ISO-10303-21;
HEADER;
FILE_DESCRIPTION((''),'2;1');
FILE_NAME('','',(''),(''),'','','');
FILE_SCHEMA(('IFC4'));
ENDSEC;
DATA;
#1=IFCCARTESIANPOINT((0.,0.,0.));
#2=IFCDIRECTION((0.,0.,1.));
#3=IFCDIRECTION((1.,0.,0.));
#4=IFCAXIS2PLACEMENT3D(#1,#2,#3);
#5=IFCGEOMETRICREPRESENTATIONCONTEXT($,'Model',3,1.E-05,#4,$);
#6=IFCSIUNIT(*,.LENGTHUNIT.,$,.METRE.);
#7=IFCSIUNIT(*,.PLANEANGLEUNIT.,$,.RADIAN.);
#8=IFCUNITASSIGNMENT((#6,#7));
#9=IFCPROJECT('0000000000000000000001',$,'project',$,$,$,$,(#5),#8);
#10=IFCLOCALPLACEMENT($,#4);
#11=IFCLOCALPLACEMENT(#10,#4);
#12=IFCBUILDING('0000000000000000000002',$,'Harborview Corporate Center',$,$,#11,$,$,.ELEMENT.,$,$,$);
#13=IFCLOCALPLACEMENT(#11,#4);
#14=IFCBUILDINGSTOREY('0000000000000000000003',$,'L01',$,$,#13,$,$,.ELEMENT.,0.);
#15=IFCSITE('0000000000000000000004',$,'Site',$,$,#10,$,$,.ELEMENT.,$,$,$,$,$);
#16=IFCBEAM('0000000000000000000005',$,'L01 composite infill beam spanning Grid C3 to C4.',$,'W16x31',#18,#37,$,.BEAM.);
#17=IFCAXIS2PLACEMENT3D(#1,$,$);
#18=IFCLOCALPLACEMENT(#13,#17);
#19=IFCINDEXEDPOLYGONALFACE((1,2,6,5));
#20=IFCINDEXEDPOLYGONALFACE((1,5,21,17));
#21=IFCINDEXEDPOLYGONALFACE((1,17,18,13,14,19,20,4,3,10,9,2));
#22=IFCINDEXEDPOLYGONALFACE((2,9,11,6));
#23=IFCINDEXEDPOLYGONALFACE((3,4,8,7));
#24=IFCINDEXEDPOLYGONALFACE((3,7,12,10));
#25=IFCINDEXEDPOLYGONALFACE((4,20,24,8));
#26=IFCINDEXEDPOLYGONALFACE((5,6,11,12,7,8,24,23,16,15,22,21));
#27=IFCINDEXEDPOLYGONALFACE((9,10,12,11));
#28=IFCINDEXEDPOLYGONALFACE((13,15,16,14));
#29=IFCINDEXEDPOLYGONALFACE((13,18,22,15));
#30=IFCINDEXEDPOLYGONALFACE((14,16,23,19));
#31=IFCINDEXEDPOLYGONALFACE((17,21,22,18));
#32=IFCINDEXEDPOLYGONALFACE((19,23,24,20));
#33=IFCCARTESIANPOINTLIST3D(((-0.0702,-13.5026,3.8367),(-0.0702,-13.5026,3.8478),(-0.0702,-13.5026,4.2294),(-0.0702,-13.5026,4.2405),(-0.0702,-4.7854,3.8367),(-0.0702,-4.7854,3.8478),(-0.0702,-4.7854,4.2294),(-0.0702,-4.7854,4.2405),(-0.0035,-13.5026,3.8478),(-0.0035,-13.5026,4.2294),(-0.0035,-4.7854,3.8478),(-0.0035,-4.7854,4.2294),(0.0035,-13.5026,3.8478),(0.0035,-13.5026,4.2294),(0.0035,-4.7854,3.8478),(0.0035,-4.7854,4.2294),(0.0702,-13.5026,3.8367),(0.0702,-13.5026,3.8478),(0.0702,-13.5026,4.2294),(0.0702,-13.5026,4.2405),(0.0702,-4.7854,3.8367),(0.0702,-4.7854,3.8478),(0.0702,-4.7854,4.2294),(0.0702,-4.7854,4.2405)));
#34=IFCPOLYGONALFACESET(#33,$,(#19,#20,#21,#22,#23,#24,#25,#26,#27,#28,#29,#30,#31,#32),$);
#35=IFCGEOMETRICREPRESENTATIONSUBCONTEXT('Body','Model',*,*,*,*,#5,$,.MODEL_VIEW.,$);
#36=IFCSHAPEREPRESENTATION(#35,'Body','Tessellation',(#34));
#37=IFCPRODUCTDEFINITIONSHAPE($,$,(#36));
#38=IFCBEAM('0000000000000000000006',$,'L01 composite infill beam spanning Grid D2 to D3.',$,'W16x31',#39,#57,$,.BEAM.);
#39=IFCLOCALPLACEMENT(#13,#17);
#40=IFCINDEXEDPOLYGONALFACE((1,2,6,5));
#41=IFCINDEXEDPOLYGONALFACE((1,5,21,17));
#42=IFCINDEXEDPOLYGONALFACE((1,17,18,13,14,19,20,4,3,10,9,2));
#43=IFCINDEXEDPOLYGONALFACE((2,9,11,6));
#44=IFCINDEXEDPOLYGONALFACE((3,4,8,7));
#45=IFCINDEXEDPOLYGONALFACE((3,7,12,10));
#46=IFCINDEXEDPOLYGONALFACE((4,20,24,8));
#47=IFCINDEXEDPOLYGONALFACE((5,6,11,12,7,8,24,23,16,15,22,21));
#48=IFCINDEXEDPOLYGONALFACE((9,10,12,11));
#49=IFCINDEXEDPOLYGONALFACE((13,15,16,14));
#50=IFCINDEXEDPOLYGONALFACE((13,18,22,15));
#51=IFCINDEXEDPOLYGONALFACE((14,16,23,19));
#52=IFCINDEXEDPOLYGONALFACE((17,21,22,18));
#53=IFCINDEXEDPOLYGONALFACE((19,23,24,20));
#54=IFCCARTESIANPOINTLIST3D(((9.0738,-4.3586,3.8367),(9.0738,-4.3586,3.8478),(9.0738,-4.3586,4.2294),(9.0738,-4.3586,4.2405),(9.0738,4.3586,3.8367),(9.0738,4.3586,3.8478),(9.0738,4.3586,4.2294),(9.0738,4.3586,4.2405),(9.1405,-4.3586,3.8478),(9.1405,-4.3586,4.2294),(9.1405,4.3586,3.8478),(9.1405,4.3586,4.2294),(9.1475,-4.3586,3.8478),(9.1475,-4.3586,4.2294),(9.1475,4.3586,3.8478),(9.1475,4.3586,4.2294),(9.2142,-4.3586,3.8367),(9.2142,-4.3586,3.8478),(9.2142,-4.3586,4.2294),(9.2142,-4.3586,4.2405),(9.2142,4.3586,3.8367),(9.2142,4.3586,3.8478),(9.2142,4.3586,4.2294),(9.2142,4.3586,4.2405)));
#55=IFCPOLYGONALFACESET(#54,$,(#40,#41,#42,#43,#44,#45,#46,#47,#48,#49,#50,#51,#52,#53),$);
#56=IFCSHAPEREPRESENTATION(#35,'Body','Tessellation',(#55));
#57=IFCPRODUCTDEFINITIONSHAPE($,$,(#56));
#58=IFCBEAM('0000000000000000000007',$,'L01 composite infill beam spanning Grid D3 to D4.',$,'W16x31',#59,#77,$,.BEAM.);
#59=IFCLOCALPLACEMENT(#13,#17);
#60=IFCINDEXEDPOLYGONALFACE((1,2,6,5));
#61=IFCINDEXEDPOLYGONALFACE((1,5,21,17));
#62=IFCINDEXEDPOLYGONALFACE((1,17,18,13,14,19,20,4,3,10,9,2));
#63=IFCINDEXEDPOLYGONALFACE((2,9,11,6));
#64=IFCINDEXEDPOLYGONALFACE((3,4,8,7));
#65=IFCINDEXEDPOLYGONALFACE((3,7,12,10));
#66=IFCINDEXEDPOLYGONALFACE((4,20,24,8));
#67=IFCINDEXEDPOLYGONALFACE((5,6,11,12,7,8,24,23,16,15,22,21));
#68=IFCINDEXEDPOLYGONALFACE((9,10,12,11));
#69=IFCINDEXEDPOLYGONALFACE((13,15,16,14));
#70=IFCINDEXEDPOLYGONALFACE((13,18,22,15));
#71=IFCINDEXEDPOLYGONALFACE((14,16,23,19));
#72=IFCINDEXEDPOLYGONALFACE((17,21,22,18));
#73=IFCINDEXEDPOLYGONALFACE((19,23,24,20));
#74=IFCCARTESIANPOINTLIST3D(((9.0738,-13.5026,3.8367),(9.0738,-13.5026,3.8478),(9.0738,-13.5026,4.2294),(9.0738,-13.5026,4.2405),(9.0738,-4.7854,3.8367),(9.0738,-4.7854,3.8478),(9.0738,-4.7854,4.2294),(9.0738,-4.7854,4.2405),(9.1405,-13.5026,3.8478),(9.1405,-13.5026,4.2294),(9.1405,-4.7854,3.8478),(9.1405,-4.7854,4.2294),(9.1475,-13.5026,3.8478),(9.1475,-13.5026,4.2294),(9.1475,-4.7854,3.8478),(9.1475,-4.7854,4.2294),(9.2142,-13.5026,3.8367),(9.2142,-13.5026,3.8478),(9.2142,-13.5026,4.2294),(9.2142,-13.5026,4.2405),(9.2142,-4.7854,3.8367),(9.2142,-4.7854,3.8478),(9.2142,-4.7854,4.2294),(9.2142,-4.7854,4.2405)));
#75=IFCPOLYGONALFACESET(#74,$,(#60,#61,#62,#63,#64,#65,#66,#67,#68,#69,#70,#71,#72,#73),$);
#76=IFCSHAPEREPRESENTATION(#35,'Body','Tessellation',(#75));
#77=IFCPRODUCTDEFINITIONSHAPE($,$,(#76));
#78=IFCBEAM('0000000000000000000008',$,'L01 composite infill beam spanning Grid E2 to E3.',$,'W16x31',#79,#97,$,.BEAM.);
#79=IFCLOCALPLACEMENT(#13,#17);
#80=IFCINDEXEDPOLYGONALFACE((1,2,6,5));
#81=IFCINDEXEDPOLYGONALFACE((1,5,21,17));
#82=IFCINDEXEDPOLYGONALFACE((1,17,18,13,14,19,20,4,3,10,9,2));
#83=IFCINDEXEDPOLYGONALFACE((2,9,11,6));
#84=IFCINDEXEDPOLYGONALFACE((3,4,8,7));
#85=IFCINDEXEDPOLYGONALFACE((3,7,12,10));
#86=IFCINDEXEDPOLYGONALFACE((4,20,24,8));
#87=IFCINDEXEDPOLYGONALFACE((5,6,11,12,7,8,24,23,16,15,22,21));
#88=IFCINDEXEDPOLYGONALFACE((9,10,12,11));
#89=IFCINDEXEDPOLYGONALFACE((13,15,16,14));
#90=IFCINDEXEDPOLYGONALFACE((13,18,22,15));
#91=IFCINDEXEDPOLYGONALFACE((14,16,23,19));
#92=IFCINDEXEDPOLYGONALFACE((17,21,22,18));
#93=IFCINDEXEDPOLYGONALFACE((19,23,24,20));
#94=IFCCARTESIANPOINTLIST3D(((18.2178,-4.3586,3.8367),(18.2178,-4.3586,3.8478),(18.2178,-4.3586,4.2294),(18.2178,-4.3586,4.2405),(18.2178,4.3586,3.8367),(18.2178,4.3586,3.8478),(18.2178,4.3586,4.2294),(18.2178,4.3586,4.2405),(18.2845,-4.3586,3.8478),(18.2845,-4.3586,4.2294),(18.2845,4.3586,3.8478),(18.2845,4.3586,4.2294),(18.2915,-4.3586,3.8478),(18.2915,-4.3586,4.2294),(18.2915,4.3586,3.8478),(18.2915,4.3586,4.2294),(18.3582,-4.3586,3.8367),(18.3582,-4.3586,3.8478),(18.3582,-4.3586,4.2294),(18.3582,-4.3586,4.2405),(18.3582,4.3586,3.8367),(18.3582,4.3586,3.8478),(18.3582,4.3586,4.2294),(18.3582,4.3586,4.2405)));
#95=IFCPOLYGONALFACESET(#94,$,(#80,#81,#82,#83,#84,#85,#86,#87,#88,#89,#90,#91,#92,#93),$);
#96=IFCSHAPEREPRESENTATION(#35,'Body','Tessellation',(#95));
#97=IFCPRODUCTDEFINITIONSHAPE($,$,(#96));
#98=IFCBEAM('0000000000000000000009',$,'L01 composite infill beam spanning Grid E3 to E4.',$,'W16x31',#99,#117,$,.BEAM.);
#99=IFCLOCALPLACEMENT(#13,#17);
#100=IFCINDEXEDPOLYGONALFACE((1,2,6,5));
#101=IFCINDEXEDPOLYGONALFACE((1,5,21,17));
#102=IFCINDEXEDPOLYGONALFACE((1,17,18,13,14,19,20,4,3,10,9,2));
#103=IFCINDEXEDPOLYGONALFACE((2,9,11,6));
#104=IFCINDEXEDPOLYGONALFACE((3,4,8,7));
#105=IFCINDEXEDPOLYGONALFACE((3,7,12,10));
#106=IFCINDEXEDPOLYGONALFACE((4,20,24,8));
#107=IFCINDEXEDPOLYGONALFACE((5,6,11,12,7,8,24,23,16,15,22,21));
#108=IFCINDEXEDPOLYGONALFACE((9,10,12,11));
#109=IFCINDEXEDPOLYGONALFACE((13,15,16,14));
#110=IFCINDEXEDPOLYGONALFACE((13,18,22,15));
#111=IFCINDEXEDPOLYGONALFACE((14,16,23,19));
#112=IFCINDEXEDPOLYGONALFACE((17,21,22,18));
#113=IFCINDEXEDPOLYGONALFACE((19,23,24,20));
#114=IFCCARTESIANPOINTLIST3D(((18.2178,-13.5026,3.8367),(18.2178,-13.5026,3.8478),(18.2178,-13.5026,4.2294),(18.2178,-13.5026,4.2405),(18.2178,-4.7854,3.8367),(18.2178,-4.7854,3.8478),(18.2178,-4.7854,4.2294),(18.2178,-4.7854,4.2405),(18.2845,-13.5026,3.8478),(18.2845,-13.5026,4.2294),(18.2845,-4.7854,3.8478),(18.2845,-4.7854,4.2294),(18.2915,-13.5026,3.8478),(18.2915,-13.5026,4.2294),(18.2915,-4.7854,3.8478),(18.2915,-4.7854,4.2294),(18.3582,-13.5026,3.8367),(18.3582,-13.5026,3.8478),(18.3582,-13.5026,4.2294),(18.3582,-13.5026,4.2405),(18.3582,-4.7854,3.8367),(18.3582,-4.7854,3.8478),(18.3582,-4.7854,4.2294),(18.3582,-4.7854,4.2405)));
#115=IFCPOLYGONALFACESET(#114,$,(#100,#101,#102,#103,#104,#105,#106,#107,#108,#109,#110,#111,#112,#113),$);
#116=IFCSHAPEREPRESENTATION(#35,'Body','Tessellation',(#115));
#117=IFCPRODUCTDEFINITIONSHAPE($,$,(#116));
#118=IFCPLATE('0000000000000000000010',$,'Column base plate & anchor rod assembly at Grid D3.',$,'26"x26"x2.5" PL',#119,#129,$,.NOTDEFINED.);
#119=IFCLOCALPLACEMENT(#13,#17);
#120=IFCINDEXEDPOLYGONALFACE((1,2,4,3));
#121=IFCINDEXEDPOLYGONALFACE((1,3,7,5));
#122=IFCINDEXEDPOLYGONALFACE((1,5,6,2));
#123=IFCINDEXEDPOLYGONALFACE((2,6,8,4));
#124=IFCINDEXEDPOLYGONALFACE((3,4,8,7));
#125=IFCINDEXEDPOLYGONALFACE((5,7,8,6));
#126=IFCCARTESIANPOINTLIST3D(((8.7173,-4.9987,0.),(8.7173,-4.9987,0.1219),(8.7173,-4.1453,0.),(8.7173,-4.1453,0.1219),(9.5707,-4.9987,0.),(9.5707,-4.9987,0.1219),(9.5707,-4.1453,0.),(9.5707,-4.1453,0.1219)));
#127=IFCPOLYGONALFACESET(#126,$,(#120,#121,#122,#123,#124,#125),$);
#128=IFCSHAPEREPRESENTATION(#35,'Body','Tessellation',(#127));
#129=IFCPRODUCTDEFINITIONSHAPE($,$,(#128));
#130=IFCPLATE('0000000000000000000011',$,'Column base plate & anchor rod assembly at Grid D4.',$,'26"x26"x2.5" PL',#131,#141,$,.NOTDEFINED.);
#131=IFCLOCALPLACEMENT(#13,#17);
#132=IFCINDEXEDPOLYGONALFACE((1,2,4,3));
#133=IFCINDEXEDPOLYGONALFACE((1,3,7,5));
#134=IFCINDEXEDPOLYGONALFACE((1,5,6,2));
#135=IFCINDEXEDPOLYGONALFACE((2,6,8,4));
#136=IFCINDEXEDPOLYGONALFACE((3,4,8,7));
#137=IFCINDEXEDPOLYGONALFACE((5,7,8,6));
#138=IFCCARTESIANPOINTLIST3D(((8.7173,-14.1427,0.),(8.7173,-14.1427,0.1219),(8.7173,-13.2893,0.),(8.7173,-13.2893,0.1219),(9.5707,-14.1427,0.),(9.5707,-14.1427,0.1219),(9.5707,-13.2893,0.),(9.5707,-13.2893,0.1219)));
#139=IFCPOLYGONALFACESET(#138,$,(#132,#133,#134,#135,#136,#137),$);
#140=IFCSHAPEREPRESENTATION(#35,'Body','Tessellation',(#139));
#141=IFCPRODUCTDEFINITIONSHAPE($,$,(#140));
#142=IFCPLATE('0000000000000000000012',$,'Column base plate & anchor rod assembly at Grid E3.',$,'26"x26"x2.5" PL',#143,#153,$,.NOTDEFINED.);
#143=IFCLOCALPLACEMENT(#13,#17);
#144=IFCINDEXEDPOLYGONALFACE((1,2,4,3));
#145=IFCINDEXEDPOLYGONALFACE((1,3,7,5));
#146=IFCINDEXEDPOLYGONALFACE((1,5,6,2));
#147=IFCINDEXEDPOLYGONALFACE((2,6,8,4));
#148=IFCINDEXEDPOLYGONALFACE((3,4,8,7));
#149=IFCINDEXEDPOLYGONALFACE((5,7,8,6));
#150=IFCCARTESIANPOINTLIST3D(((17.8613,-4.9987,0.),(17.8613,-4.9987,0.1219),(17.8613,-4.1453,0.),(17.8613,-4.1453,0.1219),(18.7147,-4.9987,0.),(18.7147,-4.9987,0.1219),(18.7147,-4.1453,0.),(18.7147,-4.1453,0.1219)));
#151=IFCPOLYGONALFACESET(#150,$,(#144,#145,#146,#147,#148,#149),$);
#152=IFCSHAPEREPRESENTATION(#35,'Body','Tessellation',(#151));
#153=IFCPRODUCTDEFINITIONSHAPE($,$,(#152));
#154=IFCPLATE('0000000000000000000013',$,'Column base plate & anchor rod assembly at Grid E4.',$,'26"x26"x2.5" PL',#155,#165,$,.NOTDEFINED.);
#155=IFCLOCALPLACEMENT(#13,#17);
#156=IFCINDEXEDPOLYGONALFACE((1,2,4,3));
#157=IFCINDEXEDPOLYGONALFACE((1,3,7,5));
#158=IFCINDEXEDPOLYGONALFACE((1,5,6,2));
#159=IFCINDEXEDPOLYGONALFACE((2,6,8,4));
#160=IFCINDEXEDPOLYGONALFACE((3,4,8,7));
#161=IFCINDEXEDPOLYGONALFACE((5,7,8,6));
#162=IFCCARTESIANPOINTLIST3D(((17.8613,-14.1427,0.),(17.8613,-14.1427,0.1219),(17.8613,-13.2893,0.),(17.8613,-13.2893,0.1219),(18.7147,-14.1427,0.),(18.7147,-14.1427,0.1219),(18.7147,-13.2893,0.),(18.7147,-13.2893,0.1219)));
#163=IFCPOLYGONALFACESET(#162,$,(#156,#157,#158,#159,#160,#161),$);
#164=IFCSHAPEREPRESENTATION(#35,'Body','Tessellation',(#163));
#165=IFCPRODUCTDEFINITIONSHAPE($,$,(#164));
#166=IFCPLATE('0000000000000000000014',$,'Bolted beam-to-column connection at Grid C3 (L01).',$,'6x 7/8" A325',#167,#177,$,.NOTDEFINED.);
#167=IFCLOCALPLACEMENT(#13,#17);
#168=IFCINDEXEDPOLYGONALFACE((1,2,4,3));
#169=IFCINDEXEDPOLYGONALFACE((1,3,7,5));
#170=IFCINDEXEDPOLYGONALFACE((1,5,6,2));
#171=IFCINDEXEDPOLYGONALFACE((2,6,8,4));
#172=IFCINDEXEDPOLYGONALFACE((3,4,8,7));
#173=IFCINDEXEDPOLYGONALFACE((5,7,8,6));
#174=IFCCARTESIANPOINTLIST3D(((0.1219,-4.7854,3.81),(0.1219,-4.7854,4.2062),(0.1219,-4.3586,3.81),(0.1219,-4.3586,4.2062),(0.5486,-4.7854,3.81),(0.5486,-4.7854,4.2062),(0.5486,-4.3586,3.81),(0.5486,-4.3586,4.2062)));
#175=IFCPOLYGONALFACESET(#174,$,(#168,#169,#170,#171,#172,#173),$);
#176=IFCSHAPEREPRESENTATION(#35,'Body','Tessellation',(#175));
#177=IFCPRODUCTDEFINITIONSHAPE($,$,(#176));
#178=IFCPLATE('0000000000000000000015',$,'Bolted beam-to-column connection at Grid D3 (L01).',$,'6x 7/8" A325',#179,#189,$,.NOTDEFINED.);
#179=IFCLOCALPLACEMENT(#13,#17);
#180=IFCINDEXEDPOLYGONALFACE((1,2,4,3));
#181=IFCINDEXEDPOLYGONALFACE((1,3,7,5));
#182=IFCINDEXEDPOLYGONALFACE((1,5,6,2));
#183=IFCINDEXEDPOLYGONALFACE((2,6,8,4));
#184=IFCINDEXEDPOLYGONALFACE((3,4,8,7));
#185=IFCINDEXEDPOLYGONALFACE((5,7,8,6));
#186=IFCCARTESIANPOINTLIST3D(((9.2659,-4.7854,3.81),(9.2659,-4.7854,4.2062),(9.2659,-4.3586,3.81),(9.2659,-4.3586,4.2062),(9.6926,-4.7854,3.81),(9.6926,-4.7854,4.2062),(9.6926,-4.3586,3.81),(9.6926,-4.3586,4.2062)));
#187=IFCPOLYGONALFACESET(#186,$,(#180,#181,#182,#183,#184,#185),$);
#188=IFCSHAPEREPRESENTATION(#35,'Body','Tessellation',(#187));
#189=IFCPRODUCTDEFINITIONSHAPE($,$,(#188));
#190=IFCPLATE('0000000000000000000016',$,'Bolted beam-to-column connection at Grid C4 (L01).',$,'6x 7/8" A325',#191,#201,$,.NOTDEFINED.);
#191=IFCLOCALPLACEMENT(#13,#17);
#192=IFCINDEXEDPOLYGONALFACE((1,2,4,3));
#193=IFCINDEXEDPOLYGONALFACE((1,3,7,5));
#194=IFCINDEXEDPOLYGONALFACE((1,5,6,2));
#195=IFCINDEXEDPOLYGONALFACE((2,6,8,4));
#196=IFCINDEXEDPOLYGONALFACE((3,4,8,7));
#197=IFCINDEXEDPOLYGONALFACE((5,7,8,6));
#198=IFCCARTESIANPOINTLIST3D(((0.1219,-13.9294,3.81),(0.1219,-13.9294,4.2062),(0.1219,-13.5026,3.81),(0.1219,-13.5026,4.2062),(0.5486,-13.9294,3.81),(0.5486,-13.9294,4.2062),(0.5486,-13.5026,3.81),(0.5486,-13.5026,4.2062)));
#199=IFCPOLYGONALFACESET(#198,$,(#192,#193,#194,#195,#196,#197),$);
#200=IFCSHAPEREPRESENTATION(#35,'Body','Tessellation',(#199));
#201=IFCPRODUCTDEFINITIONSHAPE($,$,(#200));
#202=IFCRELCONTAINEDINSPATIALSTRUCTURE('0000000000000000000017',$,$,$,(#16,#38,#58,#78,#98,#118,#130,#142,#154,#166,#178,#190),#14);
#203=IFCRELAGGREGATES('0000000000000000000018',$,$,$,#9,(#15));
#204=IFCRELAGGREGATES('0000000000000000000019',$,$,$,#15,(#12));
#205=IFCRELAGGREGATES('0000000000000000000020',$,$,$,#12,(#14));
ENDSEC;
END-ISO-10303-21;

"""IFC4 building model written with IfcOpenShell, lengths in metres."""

from ifc_helpers import new_model, si_unit, frame, origin_with_axes, place, context, subcontext, project, spatial, rectangle, i_section, extrude, element, save


model = new_model("IFC4")

# Units and contexts
model_context = context("Model", 3, precision=1e-05, world=origin_with_axes())
body_context = subcontext(model_context, "Body", "Model", "MODEL_VIEW")
ifc_project = project(units=[si_unit("LENGTHUNIT", "METRE"), si_unit("PLANEANGLEUNIT", "RADIAN")], contexts=[model_context])

# Site, building, storey
site_placement = place(None, origin_with_axes())
site = spatial("IfcSite", under=ifc_project, at=site_placement, Name="Site", CompositionType="ELEMENT")
building_placement = place(site_placement, origin_with_axes())
building = spatial("IfcBuilding", under=site, at=building_placement, Name="Harborview Corporate Center", CompositionType="ELEMENT")
storey_placement = place(building_placement, origin_with_axes())
storey = spatial("IfcBuildingStorey", under=building, at=storey_placement, Name="L01", CompositionType="ELEMENT", Elevation=0.0)

# Beams
beam_1_placement = place(storey_placement, frame((0.0, -13.5026, 4.0386), z_axis=(0.0, 1.0, 0.0), x_axis=(-1.0, 0.0, 0.0)))
element("IfcBeam", 1, at=beam_1_placement, inside=storey, Name="L01 composite infill beam spanning Grid C3 to C4.", ObjectType="W16x31", PredefinedType="BEAM", context=body_context, shape_type="SweptSolid", body=[
    extrude(i_section(OverallWidth=0.1405, OverallDepth=0.4039, WebThickness=0.007, FlangeThickness=0.0112), origin_with_axes(), (0.0, 0.0, 1.0), 8.7173),
])
beam_2_placement = place(storey_placement, frame((9.144, -4.3586, 4.0386), z_axis=(0.0, 1.0, 0.0), x_axis=(-1.0, 0.0, 0.0)))
element("IfcBeam", 2, at=beam_2_placement, inside=storey, Name="L01 composite infill beam spanning Grid D2 to D3.", ObjectType="W16x31", PredefinedType="BEAM", context=body_context, shape_type="SweptSolid", body=[
    extrude(i_section(OverallWidth=0.1405, OverallDepth=0.4039, WebThickness=0.007, FlangeThickness=0.0112), origin_with_axes(), (0.0, 0.0, 1.0), 8.7173),
])
beam_3_placement = place(storey_placement, frame((9.144, -13.5026, 4.0386), z_axis=(0.0, 1.0, 0.0), x_axis=(-1.0, 0.0, 0.0)))
element("IfcBeam", 3, at=beam_3_placement, inside=storey, Name="L01 composite infill beam spanning Grid D3 to D4.", ObjectType="W16x31", PredefinedType="BEAM", context=body_context, shape_type="SweptSolid", body=[
    extrude(i_section(OverallWidth=0.1405, OverallDepth=0.4039, WebThickness=0.007, FlangeThickness=0.0112), origin_with_axes(), (0.0, 0.0, 1.0), 8.7173),
])
beam_4_placement = place(storey_placement, frame((18.288, -4.3586, 4.0386), z_axis=(0.0, 1.0, 0.0), x_axis=(-1.0, 0.0, 0.0)))
element("IfcBeam", 4, at=beam_4_placement, inside=storey, Name="L01 composite infill beam spanning Grid E2 to E3.", ObjectType="W16x31", PredefinedType="BEAM", context=body_context, shape_type="SweptSolid", body=[
    extrude(i_section(OverallWidth=0.1405, OverallDepth=0.4039, WebThickness=0.007, FlangeThickness=0.0112), origin_with_axes(), (0.0, 0.0, 1.0), 8.7173),
])
beam_5_placement = place(storey_placement, frame((18.288, -13.5026, 4.0386), z_axis=(0.0, 1.0, 0.0), x_axis=(-1.0, 0.0, 0.0)))
element("IfcBeam", 5, at=beam_5_placement, inside=storey, Name="L01 composite infill beam spanning Grid E3 to E4.", ObjectType="W16x31", PredefinedType="BEAM", context=body_context, shape_type="SweptSolid", body=[
    extrude(i_section(OverallWidth=0.1405, OverallDepth=0.4039, WebThickness=0.007, FlangeThickness=0.0112), origin_with_axes(), (0.0, 0.0, 1.0), 8.7173),
])

# Plates
plate_1_placement = place(storey_placement, frame((9.144, -4.572, 0.0), z_axis=(0.0, 0.0, 1.0), x_axis=(1.0, 0.0, 0.0)))
element("IfcPlate", 6, at=plate_1_placement, inside=storey, Name="Column base plate & anchor rod assembly at Grid D3.", ObjectType="26\"x26\"x2.5\" PL", PredefinedType="NOTDEFINED", context=body_context, shape_type="SweptSolid", body=[
    extrude(rectangle(XDim=0.8534, YDim=0.8534), origin_with_axes(), (0.0, 0.0, 1.0), 0.1219),
])
plate_2_placement = place(storey_placement, frame((9.144, -13.716, 0.0), z_axis=(0.0, 0.0, 1.0), x_axis=(1.0, 0.0, 0.0)))
element("IfcPlate", 7, at=plate_2_placement, inside=storey, Name="Column base plate & anchor rod assembly at Grid D4.", ObjectType="26\"x26\"x2.5\" PL", PredefinedType="NOTDEFINED", context=body_context, shape_type="SweptSolid", body=[
    extrude(rectangle(XDim=0.8534, YDim=0.8534), origin_with_axes(), (0.0, 0.0, 1.0), 0.1219),
])
plate_3_placement = place(storey_placement, frame((18.288, -4.572, 0.0), z_axis=(0.0, 0.0, 1.0), x_axis=(1.0, 0.0, 0.0)))
element("IfcPlate", 8, at=plate_3_placement, inside=storey, Name="Column base plate & anchor rod assembly at Grid E3.", ObjectType="26\"x26\"x2.5\" PL", PredefinedType="NOTDEFINED", context=body_context, shape_type="SweptSolid", body=[
    extrude(rectangle(XDim=0.8534, YDim=0.8534), origin_with_axes(), (0.0, 0.0, 1.0), 0.1219),
])
plate_4_placement = place(storey_placement, frame((18.288, -13.716, 0.0), z_axis=(0.0, 0.0, 1.0), x_axis=(1.0, 0.0, 0.0)))
element("IfcPlate", 9, at=plate_4_placement, inside=storey, Name="Column base plate & anchor rod assembly at Grid E4.", ObjectType="26\"x26\"x2.5\" PL", PredefinedType="NOTDEFINED", context=body_context, shape_type="SweptSolid", body=[
    extrude(rectangle(XDim=0.8534, YDim=0.8534), origin_with_axes(), (0.0, 0.0, 1.0), 0.1219),
])
plate_5_placement = place(storey_placement, frame((0.3353, -4.572, 3.81), z_axis=(0.0, 0.0, 1.0), x_axis=(1.0, 0.0, 0.0)))
element("IfcPlate", 10, at=plate_5_placement, inside=storey, Name="Bolted beam-to-column connection at Grid C3 (L01).", ObjectType="6x 7/8\" A325", PredefinedType="NOTDEFINED", context=body_context, shape_type="SweptSolid", body=[
    extrude(rectangle(XDim=0.4267, YDim=0.4267), origin_with_axes(), (0.0, 0.0, 1.0), 0.3962),
])
plate_6_placement = place(storey_placement, frame((9.4793, -4.572, 3.81), z_axis=(0.0, 0.0, 1.0), x_axis=(1.0, 0.0, 0.0)))
element("IfcPlate", 11, at=plate_6_placement, inside=storey, Name="Bolted beam-to-column connection at Grid D3 (L01).", ObjectType="6x 7/8\" A325", PredefinedType="NOTDEFINED", context=body_context, shape_type="SweptSolid", body=[
    extrude(rectangle(XDim=0.4267, YDim=0.4267), origin_with_axes(), (0.0, 0.0, 1.0), 0.3962),
])
plate_7_placement = place(storey_placement, frame((0.3353, -13.716, 3.81), z_axis=(0.0, 0.0, 1.0), x_axis=(1.0, 0.0, 0.0)))
element("IfcPlate", 12, at=plate_7_placement, inside=storey, Name="Bolted beam-to-column connection at Grid C4 (L01).", ObjectType="6x 7/8\" A325", PredefinedType="NOTDEFINED", context=body_context, shape_type="SweptSolid", body=[
    extrude(rectangle(XDim=0.4267, YDim=0.4267), origin_with_axes(), (0.0, 0.0, 1.0), 0.3962),
])

save(model, "model.ifc")
